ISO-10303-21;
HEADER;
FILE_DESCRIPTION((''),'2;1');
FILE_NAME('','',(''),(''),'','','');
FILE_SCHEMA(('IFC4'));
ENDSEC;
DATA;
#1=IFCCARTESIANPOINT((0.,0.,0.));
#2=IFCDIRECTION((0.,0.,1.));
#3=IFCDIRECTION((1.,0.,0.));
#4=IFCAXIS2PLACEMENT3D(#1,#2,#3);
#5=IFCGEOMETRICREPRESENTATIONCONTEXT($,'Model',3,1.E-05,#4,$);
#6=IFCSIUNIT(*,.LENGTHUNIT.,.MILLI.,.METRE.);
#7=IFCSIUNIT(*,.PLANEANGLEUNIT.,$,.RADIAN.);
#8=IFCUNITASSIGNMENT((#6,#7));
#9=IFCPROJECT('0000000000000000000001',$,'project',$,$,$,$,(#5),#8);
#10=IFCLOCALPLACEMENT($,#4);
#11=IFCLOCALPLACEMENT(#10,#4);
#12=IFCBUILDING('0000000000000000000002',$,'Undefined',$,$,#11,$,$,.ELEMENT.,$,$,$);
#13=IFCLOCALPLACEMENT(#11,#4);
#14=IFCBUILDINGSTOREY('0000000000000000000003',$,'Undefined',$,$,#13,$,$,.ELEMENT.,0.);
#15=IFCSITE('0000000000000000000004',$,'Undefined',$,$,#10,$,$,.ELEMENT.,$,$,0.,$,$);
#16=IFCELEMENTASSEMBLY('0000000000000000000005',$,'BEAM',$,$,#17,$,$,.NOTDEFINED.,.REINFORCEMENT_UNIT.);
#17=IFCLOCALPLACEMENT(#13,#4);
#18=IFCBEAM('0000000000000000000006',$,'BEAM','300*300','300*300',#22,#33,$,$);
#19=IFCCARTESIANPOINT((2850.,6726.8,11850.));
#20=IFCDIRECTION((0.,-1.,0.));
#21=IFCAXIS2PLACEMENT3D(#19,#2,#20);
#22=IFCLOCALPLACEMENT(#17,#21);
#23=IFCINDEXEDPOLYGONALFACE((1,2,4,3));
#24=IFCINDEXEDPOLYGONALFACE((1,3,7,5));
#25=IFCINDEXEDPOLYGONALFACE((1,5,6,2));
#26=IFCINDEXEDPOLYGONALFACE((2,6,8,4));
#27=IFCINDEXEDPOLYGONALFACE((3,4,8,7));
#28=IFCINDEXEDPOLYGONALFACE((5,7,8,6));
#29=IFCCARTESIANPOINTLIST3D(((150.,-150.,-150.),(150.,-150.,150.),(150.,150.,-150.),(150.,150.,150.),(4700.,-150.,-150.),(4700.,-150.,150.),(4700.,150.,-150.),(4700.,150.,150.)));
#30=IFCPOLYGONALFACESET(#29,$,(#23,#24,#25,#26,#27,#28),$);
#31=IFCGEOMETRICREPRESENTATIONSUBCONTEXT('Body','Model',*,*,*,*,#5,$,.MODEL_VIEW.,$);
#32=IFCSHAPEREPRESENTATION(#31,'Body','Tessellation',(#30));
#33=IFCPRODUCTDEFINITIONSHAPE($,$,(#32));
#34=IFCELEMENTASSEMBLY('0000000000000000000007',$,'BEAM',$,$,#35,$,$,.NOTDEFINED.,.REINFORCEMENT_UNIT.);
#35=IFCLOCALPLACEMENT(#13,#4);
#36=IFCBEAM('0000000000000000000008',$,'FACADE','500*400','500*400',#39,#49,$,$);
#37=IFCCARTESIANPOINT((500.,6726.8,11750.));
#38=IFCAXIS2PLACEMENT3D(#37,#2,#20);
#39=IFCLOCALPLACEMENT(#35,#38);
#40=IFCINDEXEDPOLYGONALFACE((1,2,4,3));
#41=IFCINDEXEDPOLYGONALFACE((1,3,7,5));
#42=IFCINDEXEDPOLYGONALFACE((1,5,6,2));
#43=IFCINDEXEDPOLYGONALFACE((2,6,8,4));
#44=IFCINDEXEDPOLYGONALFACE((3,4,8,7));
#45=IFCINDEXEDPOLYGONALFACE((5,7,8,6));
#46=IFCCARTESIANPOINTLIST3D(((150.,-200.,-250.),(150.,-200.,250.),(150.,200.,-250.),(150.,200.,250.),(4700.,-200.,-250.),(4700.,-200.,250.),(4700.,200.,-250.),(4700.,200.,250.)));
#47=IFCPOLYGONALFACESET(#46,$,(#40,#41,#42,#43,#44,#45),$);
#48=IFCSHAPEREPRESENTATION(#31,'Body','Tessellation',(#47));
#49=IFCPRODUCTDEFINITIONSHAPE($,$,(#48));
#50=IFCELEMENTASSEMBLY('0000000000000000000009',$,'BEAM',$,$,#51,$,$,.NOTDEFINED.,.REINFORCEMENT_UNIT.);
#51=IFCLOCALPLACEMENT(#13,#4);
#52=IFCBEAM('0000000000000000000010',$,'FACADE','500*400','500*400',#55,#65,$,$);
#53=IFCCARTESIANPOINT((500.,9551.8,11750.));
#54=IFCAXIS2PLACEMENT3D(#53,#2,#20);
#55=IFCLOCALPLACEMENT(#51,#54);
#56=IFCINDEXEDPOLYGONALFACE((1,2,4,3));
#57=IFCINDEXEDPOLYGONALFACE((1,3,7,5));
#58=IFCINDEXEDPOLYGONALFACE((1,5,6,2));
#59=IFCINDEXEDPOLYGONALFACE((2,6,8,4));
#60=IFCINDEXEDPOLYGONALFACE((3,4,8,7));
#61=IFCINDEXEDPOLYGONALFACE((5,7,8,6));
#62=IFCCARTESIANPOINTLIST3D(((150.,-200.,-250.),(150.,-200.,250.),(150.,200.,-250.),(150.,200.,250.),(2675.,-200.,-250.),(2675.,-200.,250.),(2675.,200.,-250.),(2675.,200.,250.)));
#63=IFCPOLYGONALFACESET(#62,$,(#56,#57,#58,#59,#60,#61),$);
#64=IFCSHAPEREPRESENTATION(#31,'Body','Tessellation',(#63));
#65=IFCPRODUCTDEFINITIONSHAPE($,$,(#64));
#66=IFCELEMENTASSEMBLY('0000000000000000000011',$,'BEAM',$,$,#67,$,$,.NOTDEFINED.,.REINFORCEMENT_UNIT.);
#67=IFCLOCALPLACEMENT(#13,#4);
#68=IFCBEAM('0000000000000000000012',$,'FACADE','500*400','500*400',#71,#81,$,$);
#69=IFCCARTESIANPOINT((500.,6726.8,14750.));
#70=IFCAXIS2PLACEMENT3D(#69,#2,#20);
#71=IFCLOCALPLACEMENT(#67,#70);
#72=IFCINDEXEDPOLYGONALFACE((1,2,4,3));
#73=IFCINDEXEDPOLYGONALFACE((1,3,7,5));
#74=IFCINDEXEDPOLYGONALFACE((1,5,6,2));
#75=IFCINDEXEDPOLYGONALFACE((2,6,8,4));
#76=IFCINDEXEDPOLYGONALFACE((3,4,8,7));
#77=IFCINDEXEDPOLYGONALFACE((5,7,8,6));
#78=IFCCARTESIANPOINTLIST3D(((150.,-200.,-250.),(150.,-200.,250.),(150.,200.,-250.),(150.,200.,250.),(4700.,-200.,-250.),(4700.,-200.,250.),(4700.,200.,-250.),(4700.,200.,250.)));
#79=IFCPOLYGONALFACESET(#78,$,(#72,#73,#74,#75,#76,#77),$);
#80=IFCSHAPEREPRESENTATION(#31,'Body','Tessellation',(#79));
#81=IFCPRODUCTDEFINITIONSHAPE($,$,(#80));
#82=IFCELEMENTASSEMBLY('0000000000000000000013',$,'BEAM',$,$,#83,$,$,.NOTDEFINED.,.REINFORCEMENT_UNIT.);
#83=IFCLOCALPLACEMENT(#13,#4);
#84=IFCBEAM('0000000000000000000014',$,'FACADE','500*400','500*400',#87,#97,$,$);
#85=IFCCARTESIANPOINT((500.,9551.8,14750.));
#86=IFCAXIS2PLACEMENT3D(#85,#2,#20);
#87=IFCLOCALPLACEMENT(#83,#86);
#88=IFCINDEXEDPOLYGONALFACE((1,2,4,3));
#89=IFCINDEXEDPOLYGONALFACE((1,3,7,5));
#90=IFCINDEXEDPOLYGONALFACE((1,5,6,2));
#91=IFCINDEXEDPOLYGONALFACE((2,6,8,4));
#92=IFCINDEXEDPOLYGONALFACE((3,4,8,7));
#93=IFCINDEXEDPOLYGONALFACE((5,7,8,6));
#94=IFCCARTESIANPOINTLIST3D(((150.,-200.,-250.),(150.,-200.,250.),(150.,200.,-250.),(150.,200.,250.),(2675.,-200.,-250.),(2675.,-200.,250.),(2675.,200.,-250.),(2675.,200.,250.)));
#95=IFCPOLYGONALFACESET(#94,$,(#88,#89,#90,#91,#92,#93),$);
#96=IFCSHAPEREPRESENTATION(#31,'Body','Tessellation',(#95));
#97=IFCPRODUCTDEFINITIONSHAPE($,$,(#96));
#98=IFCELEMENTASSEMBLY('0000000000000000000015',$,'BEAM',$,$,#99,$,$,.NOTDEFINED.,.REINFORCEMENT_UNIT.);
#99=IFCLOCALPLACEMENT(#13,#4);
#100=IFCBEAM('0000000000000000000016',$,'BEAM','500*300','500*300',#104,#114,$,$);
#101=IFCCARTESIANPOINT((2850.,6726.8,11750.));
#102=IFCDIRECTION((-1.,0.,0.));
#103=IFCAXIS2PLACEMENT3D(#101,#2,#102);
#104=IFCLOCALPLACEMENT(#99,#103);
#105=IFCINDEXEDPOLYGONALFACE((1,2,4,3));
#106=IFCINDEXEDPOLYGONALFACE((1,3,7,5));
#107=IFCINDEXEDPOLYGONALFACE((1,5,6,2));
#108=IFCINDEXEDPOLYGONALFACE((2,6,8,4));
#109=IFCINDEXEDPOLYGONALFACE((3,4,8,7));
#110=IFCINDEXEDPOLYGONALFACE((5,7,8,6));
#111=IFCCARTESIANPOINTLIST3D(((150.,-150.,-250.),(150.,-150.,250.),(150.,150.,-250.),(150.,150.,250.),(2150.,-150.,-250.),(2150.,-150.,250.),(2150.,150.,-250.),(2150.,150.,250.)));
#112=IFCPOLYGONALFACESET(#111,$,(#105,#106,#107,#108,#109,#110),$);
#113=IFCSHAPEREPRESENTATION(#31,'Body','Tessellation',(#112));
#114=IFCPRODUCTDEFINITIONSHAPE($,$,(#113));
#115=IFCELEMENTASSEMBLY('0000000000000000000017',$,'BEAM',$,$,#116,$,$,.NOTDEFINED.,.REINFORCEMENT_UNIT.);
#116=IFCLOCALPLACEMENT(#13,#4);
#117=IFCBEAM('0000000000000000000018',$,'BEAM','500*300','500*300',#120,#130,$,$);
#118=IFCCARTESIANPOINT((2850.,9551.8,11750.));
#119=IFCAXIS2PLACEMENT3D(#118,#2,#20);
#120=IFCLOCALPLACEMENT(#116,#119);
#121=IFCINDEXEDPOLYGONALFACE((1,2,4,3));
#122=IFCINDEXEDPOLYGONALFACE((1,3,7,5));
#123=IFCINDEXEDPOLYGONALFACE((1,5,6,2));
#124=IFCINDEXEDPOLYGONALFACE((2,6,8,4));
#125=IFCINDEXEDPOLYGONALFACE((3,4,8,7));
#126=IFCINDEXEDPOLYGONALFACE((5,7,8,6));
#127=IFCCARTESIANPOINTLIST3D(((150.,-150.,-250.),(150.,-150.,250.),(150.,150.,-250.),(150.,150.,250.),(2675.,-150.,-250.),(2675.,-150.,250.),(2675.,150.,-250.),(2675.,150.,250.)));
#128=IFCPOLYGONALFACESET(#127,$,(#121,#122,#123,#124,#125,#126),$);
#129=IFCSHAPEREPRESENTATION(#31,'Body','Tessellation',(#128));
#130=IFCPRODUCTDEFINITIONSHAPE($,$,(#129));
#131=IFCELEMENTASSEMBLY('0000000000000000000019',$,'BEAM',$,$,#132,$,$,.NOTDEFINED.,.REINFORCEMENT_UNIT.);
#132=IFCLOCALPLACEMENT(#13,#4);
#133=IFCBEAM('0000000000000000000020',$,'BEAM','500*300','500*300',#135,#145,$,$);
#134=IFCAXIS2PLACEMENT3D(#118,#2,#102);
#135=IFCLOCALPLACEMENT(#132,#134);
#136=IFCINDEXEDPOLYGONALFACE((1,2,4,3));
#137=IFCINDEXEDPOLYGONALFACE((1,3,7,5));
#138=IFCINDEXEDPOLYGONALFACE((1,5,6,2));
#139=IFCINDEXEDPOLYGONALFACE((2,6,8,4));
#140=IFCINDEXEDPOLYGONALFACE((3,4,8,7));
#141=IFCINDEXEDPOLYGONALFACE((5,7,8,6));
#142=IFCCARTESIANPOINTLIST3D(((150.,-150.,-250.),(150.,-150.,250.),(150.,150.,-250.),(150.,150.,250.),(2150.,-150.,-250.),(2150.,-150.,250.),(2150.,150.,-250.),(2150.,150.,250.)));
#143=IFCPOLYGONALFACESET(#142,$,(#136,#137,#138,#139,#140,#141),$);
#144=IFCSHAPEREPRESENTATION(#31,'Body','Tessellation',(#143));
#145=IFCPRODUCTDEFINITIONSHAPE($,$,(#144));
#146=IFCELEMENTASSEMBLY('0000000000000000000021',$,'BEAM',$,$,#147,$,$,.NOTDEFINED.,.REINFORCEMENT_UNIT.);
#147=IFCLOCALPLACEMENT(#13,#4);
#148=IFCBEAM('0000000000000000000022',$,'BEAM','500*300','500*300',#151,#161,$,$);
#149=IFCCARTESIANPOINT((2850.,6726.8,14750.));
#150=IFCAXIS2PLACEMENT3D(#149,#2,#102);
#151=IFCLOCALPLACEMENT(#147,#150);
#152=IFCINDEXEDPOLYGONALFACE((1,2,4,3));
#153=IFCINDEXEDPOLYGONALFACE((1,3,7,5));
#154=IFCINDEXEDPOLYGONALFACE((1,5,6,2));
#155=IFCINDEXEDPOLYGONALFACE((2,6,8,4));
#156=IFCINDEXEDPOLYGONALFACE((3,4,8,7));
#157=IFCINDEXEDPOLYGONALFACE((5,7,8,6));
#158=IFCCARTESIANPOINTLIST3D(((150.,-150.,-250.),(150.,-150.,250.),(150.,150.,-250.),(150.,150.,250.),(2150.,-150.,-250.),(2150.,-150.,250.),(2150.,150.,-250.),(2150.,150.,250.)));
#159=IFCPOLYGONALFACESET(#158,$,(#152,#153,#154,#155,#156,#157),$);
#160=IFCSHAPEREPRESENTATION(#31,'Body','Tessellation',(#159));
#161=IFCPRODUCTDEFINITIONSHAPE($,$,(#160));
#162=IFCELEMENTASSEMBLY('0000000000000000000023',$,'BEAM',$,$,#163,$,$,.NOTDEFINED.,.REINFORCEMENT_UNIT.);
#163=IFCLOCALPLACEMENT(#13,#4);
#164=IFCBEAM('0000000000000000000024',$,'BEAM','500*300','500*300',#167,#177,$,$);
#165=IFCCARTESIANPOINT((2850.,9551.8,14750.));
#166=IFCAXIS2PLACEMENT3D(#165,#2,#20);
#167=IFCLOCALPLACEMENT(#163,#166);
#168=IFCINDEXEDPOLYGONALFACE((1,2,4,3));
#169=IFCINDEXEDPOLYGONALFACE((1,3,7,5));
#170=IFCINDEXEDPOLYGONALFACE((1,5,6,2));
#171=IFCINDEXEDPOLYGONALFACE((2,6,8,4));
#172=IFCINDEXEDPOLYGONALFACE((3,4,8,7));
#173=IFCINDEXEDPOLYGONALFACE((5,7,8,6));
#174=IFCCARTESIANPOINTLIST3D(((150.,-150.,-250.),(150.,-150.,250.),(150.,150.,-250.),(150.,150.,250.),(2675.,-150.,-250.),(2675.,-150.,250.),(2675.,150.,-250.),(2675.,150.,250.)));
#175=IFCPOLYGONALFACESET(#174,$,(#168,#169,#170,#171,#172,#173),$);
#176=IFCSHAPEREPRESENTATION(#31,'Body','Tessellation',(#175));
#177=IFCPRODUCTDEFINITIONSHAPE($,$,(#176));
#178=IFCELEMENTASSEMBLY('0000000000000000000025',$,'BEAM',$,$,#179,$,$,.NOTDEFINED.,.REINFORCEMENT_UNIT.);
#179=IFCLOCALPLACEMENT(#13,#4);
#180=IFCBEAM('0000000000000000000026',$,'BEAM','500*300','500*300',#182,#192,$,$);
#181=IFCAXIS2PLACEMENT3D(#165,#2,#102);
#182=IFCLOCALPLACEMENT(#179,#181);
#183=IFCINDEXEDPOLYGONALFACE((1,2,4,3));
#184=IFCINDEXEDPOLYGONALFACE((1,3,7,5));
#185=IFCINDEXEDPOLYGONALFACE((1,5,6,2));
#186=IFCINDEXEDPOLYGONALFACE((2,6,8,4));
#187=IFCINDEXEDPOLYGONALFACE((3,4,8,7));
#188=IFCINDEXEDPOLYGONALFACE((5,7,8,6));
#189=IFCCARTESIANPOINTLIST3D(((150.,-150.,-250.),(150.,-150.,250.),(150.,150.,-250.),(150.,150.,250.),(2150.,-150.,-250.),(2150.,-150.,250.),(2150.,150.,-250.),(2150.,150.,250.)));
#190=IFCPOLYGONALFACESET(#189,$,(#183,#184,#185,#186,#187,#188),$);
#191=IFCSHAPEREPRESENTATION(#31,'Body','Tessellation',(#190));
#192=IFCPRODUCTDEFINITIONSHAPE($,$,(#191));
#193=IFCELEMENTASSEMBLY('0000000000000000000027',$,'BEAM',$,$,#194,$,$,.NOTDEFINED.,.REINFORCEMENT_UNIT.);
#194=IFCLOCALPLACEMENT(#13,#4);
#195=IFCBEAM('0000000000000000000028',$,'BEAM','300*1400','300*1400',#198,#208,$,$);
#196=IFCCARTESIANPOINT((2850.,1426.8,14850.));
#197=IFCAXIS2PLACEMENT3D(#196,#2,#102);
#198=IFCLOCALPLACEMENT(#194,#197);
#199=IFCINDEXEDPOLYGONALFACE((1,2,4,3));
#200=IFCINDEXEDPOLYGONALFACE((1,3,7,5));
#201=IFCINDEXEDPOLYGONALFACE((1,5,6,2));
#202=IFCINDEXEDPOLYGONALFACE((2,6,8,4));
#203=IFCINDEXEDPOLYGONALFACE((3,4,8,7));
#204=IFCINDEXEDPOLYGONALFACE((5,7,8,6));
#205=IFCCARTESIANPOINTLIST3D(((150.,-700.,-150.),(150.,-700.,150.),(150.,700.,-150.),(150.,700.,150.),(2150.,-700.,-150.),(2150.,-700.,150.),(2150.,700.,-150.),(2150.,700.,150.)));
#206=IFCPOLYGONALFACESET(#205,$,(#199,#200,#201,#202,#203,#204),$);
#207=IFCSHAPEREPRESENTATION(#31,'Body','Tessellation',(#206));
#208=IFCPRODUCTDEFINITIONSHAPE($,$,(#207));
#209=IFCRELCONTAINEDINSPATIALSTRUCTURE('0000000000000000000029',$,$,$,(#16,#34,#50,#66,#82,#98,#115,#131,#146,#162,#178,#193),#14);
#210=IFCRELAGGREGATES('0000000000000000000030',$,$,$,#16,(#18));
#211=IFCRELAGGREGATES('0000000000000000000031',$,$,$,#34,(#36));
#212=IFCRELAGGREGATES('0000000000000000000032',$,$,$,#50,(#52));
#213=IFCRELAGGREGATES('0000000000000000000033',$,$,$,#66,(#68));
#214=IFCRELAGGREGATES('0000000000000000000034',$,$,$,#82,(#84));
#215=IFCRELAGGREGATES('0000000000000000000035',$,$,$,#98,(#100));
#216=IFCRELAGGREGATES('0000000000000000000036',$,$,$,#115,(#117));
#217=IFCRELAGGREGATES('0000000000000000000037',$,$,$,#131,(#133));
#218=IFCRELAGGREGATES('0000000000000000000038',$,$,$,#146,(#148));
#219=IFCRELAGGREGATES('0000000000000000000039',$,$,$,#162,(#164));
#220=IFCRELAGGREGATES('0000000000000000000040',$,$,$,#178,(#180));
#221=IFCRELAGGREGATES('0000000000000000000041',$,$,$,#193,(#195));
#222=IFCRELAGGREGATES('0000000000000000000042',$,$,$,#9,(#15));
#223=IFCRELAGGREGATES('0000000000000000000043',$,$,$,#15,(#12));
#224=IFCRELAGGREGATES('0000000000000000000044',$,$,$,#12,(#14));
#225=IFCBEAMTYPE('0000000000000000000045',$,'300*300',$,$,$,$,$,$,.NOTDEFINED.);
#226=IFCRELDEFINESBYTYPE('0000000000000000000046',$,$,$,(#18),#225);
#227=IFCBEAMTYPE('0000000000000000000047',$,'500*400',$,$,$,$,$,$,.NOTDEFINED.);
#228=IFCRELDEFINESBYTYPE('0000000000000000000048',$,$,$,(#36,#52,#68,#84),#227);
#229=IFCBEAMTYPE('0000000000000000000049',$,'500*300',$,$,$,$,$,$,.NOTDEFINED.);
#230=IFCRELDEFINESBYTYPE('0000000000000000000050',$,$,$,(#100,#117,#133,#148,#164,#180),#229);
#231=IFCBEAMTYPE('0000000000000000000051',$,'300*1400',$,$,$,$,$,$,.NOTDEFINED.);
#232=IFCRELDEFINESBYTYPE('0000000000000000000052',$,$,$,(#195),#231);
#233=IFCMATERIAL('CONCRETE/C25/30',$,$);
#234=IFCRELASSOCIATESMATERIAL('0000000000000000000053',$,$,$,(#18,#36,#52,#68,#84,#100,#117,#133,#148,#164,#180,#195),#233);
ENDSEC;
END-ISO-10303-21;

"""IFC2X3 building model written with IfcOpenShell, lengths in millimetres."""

from ifc_helpers import new_model, si_unit, frame, origin_with_axes, origin_2d_with_axis, place, context, subcontext, project, spatial, rectangle, extrude, material, type_object, element, aggregate, save


model = new_model("IFC2X3")

# Units and contexts
model_context = context("Model", 3, precision=1e-05, world=origin_with_axes())
body_context = subcontext(model_context, "Body", "Model", "MODEL_VIEW")
ifc_project = project(units=[si_unit("LENGTHUNIT", "METRE", prefix="MILLI"), si_unit("PLANEANGLEUNIT", "RADIAN")], contexts=[model_context])

# Site, building, storey
site_placement = place(None, origin_with_axes())
site = spatial("IfcSite", under=ifc_project, at=site_placement, Name="Undefined", CompositionType="ELEMENT", RefElevation=0.0)
building_placement = place(site_placement, origin_with_axes())
building = spatial("IfcBuilding", under=site, at=building_placement, Name="Undefined", CompositionType="ELEMENT")
storey_placement = place(building_placement, origin_with_axes())
storey = spatial("IfcBuildingStorey", under=building, at=storey_placement, Name="Undefined", CompositionType="ELEMENT", Elevation=0.0)

# Shared definitions
ifc_material_1 = material(Name="CONCRETE/C25/30")

# Element assemblies, beams
assembly_1_placement = place(storey_placement, origin_with_axes())
assembly_1 = element("IfcElementAssembly", 1, at=assembly_1_placement, inside=storey, Name="BEAM", AssemblyPlace="NOTDEFINED", PredefinedType="REINFORCEMENT_UNIT")
beam_type_1 = type_object("IfcBeamType", Name="300*300", PredefinedType="NOTDEFINED")
beam_1_placement = place(assembly_1_placement, frame((2850.0, 6726.8, 11850.0), z_axis=(0.0, 0.0, 1.0), x_axis=(0.0, -1.0, 0.0)))
beam_1 = element("IfcBeam", 2, at=beam_1_placement, type_object=beam_type_1, material=ifc_material_1, Name="BEAM", Description="300*300", ObjectType="300*300", context=body_context, shape_type="SweptSolid", body=[
    extrude(rectangle(XDim=300.0, YDim=300.0, at=origin_2d_with_axis()), frame((4700.0, 0.0, 0.0), z_axis=(-1.0, 0.0, 0.0), x_axis=(0.0, -1.0, 0.0)), (0.0, 0.0, 1.0), 4550.0),
])
aggregate(assembly_1, [beam_1])
assembly_2_placement = place(storey_placement, origin_with_axes())
assembly_2 = element("IfcElementAssembly", 3, at=assembly_2_placement, inside=storey, Name="BEAM", AssemblyPlace="NOTDEFINED", PredefinedType="REINFORCEMENT_UNIT")
beam_type_2 = type_object("IfcBeamType", Name="500*400", PredefinedType="NOTDEFINED")
beam_2_placement = place(assembly_2_placement, frame((500.0, 6726.8, 11750.0), z_axis=(0.0, 0.0, 1.0), x_axis=(0.0, -1.0, 0.0)))
beam_2 = element("IfcBeam", 4, at=beam_2_placement, type_object=beam_type_2, material=ifc_material_1, Name="FACADE", Description="500*400", ObjectType="500*400", context=body_context, shape_type="SweptSolid", body=[
    extrude(rectangle(XDim=400.0, YDim=500.0, at=origin_2d_with_axis()), frame((4700.0, 0.0, 0.0), z_axis=(-1.0, 0.0, 0.0), x_axis=(0.0, -1.0, 0.0)), (0.0, 0.0, 1.0), 4550.0),
])
aggregate(assembly_2, [beam_2])
assembly_3_placement = place(storey_placement, origin_with_axes())
assembly_3 = element("IfcElementAssembly", 5, at=assembly_3_placement, inside=storey, Name="BEAM", AssemblyPlace="NOTDEFINED", PredefinedType="REINFORCEMENT_UNIT")
beam_3_placement = place(assembly_3_placement, frame((500.0, 9551.8, 11750.0), z_axis=(0.0, 0.0, 1.0), x_axis=(0.0, -1.0, 0.0)))
beam_3 = element("IfcBeam", 6, at=beam_3_placement, type_object=beam_type_2, material=ifc_material_1, Name="FACADE", Description="500*400", ObjectType="500*400", context=body_context, shape_type="SweptSolid", body=[
    extrude(rectangle(XDim=400.0, YDim=500.0, at=origin_2d_with_axis()), frame((2675.0, 0.0, 0.0), z_axis=(-1.0, 0.0, 0.0), x_axis=(0.0, -1.0, 0.0)), (0.0, 0.0, 1.0), 2525.0),
])
aggregate(assembly_3, [beam_3])
assembly_4_placement = place(storey_placement, origin_with_axes())
assembly_4 = element("IfcElementAssembly", 7, at=assembly_4_placement, inside=storey, Name="BEAM", AssemblyPlace="NOTDEFINED", PredefinedType="REINFORCEMENT_UNIT")
beam_4_placement = place(assembly_4_placement, frame((500.0, 6726.8, 14750.0), z_axis=(0.0, 0.0, 1.0), x_axis=(0.0, -1.0, 0.0)))
beam_4 = element("IfcBeam", 8, at=beam_4_placement, type_object=beam_type_2, material=ifc_material_1, Name="FACADE", Description="500*400", ObjectType="500*400", context=body_context, shape_type="SweptSolid", body=[
    extrude(rectangle(XDim=400.0, YDim=500.0, at=origin_2d_with_axis()), frame((4700.0, 0.0, 0.0), z_axis=(-1.0, 0.0, 0.0), x_axis=(0.0, -1.0, 0.0)), (0.0, 0.0, 1.0), 4550.0),
])
aggregate(assembly_4, [beam_4])
assembly_5_placement = place(storey_placement, origin_with_axes())
assembly_5 = element("IfcElementAssembly", 9, at=assembly_5_placement, inside=storey, Name="BEAM", AssemblyPlace="NOTDEFINED", PredefinedType="REINFORCEMENT_UNIT")
beam_5_placement = place(assembly_5_placement, frame((500.0, 9551.8, 14750.0), z_axis=(0.0, 0.0, 1.0), x_axis=(0.0, -1.0, 0.0)))
beam_5 = element("IfcBeam", 10, at=beam_5_placement, type_object=beam_type_2, material=ifc_material_1, Name="FACADE", Description="500*400", ObjectType="500*400", context=body_context, shape_type="SweptSolid", body=[
    extrude(rectangle(XDim=400.0, YDim=500.0, at=origin_2d_with_axis()), frame((2675.0, 0.0, 0.0), z_axis=(-1.0, 0.0, 0.0), x_axis=(0.0, -1.0, 0.0)), (0.0, 0.0, 1.0), 2525.0),
])
aggregate(assembly_5, [beam_5])
assembly_6_placement = place(storey_placement, origin_with_axes())
assembly_6 = element("IfcElementAssembly", 11, at=assembly_6_placement, inside=storey, Name="BEAM", AssemblyPlace="NOTDEFINED", PredefinedType="REINFORCEMENT_UNIT")
beam_type_3 = type_object("IfcBeamType", Name="500*300", PredefinedType="NOTDEFINED")
beam_6_placement = place(assembly_6_placement, frame((2850.0, 6726.8, 11750.0), z_axis=(0.0, 0.0, 1.0), x_axis=(-1.0, 0.0, 0.0)))
beam_6 = element("IfcBeam", 12, at=beam_6_placement, type_object=beam_type_3, material=ifc_material_1, Name="BEAM", Description="500*300", ObjectType="500*300", context=body_context, shape_type="SweptSolid", body=[
    extrude(rectangle(XDim=300.0, YDim=500.0, at=origin_2d_with_axis()), frame((2150.0, 0.0, 0.0), z_axis=(-1.0, 0.0, 0.0), x_axis=(0.0, -1.0, 0.0)), (0.0, 0.0, 1.0), 2000.0),
])
aggregate(assembly_6, [beam_6])
assembly_7_placement = place(storey_placement, origin_with_axes())
assembly_7 = element("IfcElementAssembly", 13, at=assembly_7_placement, inside=storey, Name="BEAM", AssemblyPlace="NOTDEFINED", PredefinedType="REINFORCEMENT_UNIT")
beam_7_placement = place(assembly_7_placement, frame((2850.0, 9551.8, 11750.0), z_axis=(0.0, 0.0, 1.0), x_axis=(0.0, -1.0, 0.0)))
beam_7 = element("IfcBeam", 14, at=beam_7_placement, type_object=beam_type_3, material=ifc_material_1, Name="BEAM", Description="500*300", ObjectType="500*300", context=body_context, shape_type="SweptSolid", body=[
    extrude(rectangle(XDim=300.0, YDim=500.0, at=origin_2d_with_axis()), frame((2675.0, 0.0, 0.0), z_axis=(-1.0, 0.0, 0.0), x_axis=(0.0, -1.0, 0.0)), (0.0, 0.0, 1.0), 2525.0),
])
aggregate(assembly_7, [beam_7])
assembly_8_placement = place(storey_placement, origin_with_axes())
assembly_8 = element("IfcElementAssembly", 15, at=assembly_8_placement, inside=storey, Name="BEAM", AssemblyPlace="NOTDEFINED", PredefinedType="REINFORCEMENT_UNIT")
beam_8_placement = place(assembly_8_placement, frame((2850.0, 9551.8, 11750.0), z_axis=(0.0, 0.0, 1.0), x_axis=(-1.0, 0.0, 0.0)))
beam_8 = element("IfcBeam", 16, at=beam_8_placement, type_object=beam_type_3, material=ifc_material_1, Name="BEAM", Description="500*300", ObjectType="500*300", context=body_context, shape_type="SweptSolid", body=[
    extrude(rectangle(XDim=300.0, YDim=500.0, at=origin_2d_with_axis()), frame((2150.0, 0.0, 0.0), z_axis=(-1.0, 0.0, 0.0), x_axis=(0.0, -1.0, 0.0)), (0.0, 0.0, 1.0), 2000.0),
])
aggregate(assembly_8, [beam_8])
assembly_9_placement = place(storey_placement, origin_with_axes())
assembly_9 = element("IfcElementAssembly", 17, at=assembly_9_placement, inside=storey, Name="BEAM", AssemblyPlace="NOTDEFINED", PredefinedType="REINFORCEMENT_UNIT")
beam_9_placement = place(assembly_9_placement, frame((2850.0, 6726.8, 14750.0), z_axis=(0.0, 0.0, 1.0), x_axis=(-1.0, 0.0, 0.0)))
beam_9 = element("IfcBeam", 18, at=beam_9_placement, type_object=beam_type_3, material=ifc_material_1, Name="BEAM", Description="500*300", ObjectType="500*300", context=body_context, shape_type="SweptSolid", body=[
    extrude(rectangle(XDim=300.0, YDim=500.0, at=origin_2d_with_axis()), frame((2150.0, 0.0, 0.0), z_axis=(-1.0, 0.0, 0.0), x_axis=(0.0, -1.0, 0.0)), (0.0, 0.0, 1.0), 2000.0),
])
aggregate(assembly_9, [beam_9])
assembly_10_placement = place(storey_placement, origin_with_axes())
assembly_10 = element("IfcElementAssembly", 19, at=assembly_10_placement, inside=storey, Name="BEAM", AssemblyPlace="NOTDEFINED", PredefinedType="REINFORCEMENT_UNIT")
beam_10_placement = place(assembly_10_placement, frame((2850.0, 9551.8, 14750.0), z_axis=(0.0, 0.0, 1.0), x_axis=(0.0, -1.0, 0.0)))
beam_10 = element("IfcBeam", 20, at=beam_10_placement, type_object=beam_type_3, material=ifc_material_1, Name="BEAM", Description="500*300", ObjectType="500*300", context=body_context, shape_type="SweptSolid", body=[
    extrude(rectangle(XDim=300.0, YDim=500.0, at=origin_2d_with_axis()), frame((2675.0, 0.0, 0.0), z_axis=(-1.0, 0.0, 0.0), x_axis=(0.0, -1.0, 0.0)), (0.0, 0.0, 1.0), 2525.0),
])
aggregate(assembly_10, [beam_10])
assembly_11_placement = place(storey_placement, origin_with_axes())
assembly_11 = element("IfcElementAssembly", 21, at=assembly_11_placement, inside=storey, Name="BEAM", AssemblyPlace="NOTDEFINED", PredefinedType="REINFORCEMENT_UNIT")
beam_11_placement = place(assembly_11_placement, frame((2850.0, 9551.8, 14750.0), z_axis=(0.0, 0.0, 1.0), x_axis=(-1.0, 0.0, 0.0)))
beam_11 = element("IfcBeam", 22, at=beam_11_placement, type_object=beam_type_3, material=ifc_material_1, Name="BEAM", Description="500*300", ObjectType="500*300", context=body_context, shape_type="SweptSolid", body=[
    extrude(rectangle(XDim=300.0, YDim=500.0, at=origin_2d_with_axis()), frame((2150.0, 0.0, 0.0), z_axis=(-1.0, 0.0, 0.0), x_axis=(0.0, -1.0, 0.0)), (0.0, 0.0, 1.0), 2000.0),
])
aggregate(assembly_11, [beam_11])
assembly_12_placement = place(storey_placement, origin_with_axes())
assembly_12 = element("IfcElementAssembly", 23, at=assembly_12_placement, inside=storey, Name="BEAM", AssemblyPlace="NOTDEFINED", PredefinedType="REINFORCEMENT_UNIT")
beam_type_4 = type_object("IfcBeamType", Name="300*1400", PredefinedType="NOTDEFINED")
beam_12_placement = place(assembly_12_placement, frame((2850.0, 1426.8, 14850.0), z_axis=(0.0, 0.0, 1.0), x_axis=(-1.0, 0.0, 0.0)))
beam_12 = element("IfcBeam", 24, at=beam_12_placement, type_object=beam_type_4, material=ifc_material_1, Name="BEAM", Description="300*1400", ObjectType="300*1400", context=body_context, shape_type="SweptSolid", body=[
    extrude(rectangle(XDim=1400.0, YDim=300.0, at=origin_2d_with_axis()), frame((2150.0, 0.0, 0.0), z_axis=(-1.0, 0.0, 0.0), x_axis=(0.0, -1.0, 0.0)), (0.0, 0.0, 1.0), 2000.0),
])
aggregate(assembly_12, [beam_12])

save(model, "model.ifc")
